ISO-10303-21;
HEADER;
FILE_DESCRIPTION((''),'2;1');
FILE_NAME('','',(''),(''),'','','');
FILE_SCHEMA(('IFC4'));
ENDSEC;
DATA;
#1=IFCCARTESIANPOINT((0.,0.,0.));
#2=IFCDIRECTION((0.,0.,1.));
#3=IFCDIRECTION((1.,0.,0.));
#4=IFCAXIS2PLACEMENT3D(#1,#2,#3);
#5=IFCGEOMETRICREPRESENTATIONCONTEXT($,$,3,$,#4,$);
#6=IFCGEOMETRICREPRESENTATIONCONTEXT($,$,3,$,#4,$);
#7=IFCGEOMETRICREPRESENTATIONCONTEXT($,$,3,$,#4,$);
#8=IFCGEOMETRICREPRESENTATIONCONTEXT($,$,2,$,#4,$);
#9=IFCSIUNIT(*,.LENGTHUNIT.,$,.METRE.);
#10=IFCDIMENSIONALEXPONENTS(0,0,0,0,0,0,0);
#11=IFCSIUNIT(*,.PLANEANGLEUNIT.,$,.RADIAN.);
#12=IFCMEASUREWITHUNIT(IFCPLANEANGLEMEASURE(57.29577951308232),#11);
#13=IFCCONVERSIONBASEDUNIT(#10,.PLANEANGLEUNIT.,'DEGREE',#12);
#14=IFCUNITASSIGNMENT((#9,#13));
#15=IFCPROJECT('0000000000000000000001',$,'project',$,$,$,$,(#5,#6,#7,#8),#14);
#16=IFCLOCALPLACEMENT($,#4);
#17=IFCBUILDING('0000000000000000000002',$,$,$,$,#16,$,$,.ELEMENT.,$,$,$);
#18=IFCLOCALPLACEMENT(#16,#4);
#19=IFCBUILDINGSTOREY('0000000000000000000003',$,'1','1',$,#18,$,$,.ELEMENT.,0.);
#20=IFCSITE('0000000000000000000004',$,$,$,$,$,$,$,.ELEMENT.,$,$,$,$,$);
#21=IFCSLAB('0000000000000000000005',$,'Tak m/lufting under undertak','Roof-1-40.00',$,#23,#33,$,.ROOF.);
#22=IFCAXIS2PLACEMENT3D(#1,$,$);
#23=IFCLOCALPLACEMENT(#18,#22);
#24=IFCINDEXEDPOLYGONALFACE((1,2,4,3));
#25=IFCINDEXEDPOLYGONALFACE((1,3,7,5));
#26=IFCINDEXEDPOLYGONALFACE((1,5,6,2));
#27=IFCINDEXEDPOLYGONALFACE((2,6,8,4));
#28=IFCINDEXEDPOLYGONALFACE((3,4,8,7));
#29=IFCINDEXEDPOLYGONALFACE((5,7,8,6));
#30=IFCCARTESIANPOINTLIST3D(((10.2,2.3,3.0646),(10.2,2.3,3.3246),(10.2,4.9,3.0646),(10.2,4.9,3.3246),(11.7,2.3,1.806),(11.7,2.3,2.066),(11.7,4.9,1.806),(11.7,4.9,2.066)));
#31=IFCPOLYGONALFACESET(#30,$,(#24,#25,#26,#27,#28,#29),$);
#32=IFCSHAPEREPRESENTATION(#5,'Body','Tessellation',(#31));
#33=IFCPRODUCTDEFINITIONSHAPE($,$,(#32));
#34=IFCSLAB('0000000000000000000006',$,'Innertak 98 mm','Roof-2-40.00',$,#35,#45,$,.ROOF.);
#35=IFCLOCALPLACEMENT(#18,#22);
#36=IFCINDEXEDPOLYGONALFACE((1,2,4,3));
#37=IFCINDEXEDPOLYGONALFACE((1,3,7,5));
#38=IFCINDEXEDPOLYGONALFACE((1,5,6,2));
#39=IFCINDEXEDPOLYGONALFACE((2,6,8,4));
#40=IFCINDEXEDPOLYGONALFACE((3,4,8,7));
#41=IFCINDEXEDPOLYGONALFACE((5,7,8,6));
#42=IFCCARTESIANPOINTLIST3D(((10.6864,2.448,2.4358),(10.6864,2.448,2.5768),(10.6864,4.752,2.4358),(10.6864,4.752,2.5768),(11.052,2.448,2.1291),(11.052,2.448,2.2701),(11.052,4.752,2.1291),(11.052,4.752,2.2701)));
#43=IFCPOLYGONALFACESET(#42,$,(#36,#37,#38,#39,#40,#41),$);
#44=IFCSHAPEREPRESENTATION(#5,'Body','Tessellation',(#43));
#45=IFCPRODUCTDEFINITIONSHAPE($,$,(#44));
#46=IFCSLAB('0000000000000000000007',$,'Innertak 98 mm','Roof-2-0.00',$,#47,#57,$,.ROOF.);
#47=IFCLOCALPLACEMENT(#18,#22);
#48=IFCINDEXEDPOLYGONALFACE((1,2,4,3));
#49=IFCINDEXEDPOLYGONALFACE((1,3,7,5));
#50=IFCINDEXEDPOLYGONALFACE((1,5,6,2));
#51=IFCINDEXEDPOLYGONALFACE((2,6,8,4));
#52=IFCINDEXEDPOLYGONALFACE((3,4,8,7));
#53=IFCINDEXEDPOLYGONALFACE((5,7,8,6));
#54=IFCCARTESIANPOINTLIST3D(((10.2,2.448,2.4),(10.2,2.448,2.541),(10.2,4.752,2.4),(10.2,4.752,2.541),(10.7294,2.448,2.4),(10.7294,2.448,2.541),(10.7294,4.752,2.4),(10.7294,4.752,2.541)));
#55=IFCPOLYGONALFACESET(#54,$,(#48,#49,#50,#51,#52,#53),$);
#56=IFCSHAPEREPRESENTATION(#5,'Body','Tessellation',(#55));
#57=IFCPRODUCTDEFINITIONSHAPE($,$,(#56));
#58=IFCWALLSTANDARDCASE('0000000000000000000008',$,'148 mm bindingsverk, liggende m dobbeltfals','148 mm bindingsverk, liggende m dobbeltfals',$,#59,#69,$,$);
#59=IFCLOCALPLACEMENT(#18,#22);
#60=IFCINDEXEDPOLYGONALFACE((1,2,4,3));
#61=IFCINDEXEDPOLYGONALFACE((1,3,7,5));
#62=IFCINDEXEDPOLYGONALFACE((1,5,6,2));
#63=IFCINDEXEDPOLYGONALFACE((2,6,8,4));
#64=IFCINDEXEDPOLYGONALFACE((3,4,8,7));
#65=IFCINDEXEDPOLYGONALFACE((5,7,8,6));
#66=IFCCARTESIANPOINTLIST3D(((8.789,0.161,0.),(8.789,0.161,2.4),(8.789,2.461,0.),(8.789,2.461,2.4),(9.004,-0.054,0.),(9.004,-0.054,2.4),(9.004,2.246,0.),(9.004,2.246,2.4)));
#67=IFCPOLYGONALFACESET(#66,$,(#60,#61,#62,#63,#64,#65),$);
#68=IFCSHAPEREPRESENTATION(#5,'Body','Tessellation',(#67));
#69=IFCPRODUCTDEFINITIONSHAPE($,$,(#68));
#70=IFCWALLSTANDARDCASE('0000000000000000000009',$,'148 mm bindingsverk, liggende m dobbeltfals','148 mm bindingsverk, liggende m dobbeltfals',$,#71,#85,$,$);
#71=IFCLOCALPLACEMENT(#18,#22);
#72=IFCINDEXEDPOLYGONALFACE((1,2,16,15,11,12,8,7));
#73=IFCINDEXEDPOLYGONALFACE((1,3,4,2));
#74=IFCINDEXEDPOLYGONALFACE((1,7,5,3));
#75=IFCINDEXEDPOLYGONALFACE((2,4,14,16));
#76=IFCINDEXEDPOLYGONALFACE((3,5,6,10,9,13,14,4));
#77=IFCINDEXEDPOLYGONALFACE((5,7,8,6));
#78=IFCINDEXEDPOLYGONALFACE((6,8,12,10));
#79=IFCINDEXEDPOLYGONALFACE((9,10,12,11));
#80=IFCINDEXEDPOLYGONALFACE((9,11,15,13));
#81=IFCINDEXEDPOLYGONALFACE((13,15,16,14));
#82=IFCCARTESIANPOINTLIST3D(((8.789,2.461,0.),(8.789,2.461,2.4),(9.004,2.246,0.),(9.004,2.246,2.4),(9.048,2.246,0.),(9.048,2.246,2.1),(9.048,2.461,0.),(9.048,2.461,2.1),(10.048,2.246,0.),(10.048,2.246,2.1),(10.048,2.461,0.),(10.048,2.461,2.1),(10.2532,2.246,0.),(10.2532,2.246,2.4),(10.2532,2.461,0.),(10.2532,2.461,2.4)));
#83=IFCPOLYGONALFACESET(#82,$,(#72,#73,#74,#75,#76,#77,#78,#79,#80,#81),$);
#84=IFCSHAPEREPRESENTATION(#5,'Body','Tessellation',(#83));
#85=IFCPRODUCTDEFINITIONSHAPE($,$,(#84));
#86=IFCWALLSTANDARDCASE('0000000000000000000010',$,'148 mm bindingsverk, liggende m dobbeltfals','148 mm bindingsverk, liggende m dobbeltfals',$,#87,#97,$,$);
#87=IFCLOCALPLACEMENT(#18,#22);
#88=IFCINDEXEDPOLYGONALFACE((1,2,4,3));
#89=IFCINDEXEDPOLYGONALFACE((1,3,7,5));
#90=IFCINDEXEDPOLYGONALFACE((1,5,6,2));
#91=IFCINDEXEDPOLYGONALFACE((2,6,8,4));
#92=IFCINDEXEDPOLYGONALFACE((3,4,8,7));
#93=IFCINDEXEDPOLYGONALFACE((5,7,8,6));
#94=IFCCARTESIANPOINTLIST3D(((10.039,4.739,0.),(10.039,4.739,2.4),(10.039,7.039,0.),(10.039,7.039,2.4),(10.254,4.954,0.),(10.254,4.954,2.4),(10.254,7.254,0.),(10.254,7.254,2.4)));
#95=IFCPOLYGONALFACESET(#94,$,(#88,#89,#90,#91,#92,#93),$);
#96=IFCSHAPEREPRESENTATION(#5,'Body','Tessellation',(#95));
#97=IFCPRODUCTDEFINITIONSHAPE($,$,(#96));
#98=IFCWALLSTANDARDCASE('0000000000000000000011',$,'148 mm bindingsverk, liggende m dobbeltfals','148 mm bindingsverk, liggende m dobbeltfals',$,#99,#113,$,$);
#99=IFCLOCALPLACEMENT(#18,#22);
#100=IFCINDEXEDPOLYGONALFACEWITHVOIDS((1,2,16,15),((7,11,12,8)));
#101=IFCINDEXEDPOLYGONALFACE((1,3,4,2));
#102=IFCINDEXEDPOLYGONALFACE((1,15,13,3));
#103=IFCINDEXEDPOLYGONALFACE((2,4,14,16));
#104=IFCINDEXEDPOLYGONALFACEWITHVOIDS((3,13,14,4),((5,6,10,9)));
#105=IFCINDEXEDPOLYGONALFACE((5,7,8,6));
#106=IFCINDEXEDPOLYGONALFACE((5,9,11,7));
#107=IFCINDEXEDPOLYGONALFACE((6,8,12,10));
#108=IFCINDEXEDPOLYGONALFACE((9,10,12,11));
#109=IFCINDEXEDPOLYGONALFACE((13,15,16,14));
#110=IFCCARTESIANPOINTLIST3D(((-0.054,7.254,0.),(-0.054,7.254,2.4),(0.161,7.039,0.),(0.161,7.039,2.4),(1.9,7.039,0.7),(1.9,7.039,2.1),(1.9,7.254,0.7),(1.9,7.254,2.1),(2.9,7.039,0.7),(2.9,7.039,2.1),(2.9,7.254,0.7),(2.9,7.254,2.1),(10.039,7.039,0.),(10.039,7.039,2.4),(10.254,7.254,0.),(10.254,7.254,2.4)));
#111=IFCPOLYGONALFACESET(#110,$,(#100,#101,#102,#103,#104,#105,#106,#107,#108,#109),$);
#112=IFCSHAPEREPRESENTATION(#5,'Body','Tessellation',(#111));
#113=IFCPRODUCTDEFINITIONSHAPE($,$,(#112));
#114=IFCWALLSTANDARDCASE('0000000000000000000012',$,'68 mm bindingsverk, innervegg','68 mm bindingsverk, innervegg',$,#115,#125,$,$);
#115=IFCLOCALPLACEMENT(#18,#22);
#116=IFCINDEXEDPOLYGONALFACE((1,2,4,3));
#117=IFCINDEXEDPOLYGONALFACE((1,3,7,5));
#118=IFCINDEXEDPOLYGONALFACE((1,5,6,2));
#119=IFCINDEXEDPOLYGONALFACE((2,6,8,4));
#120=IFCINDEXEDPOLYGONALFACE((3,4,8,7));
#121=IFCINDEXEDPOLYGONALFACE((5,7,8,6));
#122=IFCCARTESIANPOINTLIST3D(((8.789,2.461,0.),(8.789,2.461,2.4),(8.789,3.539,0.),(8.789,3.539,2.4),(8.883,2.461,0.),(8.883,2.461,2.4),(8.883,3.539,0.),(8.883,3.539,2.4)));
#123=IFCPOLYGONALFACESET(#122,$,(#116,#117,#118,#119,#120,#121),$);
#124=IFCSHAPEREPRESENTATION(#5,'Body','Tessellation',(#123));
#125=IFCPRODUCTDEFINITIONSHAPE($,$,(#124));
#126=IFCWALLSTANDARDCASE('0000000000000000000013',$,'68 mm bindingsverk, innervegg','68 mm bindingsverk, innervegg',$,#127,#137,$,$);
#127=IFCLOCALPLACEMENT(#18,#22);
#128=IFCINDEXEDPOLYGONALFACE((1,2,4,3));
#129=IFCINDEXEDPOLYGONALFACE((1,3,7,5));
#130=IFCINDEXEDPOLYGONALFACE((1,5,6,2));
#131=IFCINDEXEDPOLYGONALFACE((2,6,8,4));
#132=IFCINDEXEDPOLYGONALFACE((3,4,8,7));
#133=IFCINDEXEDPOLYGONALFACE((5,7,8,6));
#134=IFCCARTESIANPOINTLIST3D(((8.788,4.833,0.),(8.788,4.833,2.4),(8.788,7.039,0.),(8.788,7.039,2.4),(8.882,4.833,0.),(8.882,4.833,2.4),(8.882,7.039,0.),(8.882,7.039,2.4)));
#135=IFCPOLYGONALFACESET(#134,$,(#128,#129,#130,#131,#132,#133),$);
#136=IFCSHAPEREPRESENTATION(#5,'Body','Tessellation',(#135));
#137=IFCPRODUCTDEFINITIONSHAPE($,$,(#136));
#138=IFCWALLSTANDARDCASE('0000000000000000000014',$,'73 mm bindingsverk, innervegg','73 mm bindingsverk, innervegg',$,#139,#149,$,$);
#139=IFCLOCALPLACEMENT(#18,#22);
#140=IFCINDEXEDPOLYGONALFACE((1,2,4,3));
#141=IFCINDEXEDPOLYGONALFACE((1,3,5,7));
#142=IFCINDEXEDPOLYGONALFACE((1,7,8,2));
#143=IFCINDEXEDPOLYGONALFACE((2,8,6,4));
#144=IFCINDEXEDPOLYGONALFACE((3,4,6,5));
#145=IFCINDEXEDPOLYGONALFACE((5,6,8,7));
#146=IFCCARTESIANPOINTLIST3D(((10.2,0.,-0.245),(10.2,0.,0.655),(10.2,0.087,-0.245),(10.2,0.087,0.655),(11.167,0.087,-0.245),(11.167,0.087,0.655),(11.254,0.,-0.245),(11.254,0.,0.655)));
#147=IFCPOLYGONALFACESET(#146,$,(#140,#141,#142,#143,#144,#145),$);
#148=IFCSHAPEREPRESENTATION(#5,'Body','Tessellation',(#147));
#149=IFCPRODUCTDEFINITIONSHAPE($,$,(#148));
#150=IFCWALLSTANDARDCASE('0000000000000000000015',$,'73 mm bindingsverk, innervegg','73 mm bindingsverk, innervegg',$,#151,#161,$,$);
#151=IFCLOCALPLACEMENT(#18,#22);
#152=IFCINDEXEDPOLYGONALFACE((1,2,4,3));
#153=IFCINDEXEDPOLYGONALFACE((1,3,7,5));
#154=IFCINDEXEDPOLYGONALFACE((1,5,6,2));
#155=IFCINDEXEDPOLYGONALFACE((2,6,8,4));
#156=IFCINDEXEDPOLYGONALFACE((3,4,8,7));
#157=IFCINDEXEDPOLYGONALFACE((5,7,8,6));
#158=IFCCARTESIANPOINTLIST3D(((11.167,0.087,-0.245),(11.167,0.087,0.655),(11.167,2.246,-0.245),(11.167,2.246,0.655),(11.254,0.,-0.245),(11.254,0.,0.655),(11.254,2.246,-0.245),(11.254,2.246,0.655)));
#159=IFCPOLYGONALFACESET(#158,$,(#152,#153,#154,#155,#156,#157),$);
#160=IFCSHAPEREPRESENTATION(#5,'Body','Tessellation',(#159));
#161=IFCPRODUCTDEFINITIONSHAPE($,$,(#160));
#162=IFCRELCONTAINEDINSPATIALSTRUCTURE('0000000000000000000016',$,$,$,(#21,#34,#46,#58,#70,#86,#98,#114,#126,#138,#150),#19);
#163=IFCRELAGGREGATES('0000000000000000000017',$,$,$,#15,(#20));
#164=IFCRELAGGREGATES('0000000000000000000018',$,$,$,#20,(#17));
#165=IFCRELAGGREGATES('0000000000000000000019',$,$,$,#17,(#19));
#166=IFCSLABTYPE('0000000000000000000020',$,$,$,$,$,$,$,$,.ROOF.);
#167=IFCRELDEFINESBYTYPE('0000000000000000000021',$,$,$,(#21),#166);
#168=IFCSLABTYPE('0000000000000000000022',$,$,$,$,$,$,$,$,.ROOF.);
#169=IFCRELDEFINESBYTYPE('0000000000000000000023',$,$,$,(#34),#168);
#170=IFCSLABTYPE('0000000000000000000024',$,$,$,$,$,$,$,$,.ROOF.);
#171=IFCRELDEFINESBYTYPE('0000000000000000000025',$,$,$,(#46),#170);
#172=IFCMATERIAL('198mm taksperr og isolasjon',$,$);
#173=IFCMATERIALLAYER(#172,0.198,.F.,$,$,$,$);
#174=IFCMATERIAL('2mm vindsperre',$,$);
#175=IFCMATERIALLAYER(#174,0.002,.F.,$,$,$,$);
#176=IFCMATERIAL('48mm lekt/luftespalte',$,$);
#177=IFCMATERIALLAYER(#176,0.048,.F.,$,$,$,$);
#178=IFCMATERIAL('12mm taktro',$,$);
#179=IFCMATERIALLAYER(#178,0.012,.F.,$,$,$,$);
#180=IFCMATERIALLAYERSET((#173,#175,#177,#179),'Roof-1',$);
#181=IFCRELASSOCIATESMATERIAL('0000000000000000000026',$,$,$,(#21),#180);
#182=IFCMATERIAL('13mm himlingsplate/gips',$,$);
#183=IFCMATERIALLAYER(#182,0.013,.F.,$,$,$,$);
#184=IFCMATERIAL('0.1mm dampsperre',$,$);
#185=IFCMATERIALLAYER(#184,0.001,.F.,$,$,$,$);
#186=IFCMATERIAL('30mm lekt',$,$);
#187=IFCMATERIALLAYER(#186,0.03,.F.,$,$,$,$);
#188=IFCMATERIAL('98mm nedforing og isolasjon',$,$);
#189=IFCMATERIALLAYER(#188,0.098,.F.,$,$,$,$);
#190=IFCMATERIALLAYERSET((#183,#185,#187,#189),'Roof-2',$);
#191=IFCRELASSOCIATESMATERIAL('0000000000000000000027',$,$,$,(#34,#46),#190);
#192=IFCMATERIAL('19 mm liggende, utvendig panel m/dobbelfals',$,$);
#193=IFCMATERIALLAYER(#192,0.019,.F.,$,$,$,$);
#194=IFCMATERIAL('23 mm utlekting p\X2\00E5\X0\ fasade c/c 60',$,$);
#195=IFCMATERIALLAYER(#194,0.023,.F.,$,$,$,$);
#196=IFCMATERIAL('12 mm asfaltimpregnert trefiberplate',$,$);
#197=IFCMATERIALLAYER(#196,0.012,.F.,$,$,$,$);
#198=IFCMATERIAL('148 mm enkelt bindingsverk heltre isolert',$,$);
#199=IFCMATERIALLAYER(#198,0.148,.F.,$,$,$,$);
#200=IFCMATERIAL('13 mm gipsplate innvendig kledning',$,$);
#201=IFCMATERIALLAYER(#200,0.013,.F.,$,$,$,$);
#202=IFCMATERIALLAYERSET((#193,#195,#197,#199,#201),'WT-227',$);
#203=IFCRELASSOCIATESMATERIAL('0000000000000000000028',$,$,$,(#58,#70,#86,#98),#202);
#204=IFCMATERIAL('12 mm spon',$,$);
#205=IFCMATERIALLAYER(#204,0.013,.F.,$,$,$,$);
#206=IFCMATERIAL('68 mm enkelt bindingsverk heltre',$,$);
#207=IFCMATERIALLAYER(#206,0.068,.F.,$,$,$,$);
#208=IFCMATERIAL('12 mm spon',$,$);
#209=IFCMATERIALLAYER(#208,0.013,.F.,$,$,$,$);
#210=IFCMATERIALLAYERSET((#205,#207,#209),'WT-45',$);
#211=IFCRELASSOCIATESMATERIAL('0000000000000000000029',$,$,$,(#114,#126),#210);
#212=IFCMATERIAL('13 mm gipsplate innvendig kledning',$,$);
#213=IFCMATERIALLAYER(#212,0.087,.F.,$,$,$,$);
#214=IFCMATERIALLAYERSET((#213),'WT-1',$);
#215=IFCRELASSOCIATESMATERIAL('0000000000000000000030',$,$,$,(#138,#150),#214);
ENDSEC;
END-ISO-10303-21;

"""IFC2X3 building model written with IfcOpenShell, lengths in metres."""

from ifc_helpers import new_model, entity, si_unit, converted_unit, frame, origin_with_axes, place, context, project, spatial, polyline, outline, extrude, material, layer, layer_set, layer_usage, type_object, element, save


model = new_model("IFC2X3")

# Units and contexts
context_of_model_1 = context(None, 3, world=origin_with_axes())
context_of_model_2 = context(None, 3, world=origin_with_axes())
context_of_model_3 = context(None, 3, world=origin_with_axes())
context_of_model_4 = context(None, 2, world=origin_with_axes())
ifc_project = project(units=[si_unit("LENGTHUNIT", "METRE"), converted_unit("PLANEANGLEUNIT", "DEGREE", entity("IfcPlaneAngleMeasure", 57.29577951308232), si_unit("PLANEANGLEUNIT", "RADIAN"), dimensions=[0, 0, 0, 0, 0, 0, 0])], contexts=[context_of_model_1, context_of_model_2, context_of_model_3, context_of_model_4])

# Site, building, storey
site = spatial("IfcSite", under=ifc_project, CompositionType="ELEMENT")
building_placement = place(None, origin_with_axes())
building = spatial("IfcBuilding", under=site, at=building_placement, CompositionType="ELEMENT")
storey_placement = place(building_placement, origin_with_axes())
storey = spatial("IfcBuildingStorey", under=building, at=storey_placement, Name="1", Description="1", CompositionType="ELEMENT", Elevation=0.0)

# Slabs
ifc_material_1 = material(Name="198mm taksperr og isolasjon")
ifc_layer_1 = layer(ifc_material_1, 0.198, ventilated=False)
ifc_material_2 = material(Name="2mm vindsperre")
ifc_layer_2 = layer(ifc_material_2, 0.002, ventilated=False)
ifc_material_3 = material(Name="48mm lekt/luftespalte")
ifc_layer_3 = layer(ifc_material_3, 0.048, ventilated=False)
ifc_material_4 = material(Name="12mm taktro")
ifc_layer_4 = layer(ifc_material_4, 0.012, ventilated=False)
ifc_layer_set_1 = layer_set([ifc_layer_1, ifc_layer_2, ifc_layer_3, ifc_layer_4], Name="Roof-1")
ifc_layer_usage_1 = layer_usage(ifc_layer_set_1, "AXIS3", "NEGATIVE", 0.0)
slab_type_1 = type_object("IfcSlabType", PredefinedType="ROOF")
slab_1_placement = place(storey_placement, frame((10.2, 4.9, 3.0646), z_axis=(0.642788, 0.000003, 0.766044), x_axis=(0.000004, -1.0, 0.0)))
element("IfcSlab", 1, at=slab_1_placement, inside=storey, type_object=slab_type_1, material=ifc_layer_usage_1, Name="Tak m/lufting under undertak", Description="Roof-1-40.00", PredefinedType="ROOF", context=context_of_model_1, shape_type="SweptSolid", body=[
    extrude(outline(polyline([(0.0, 0.0), (1.9581, 0.0), (1.9581, 2.6), (0.0, 2.6), (0.0, 0.0)])), frame((0.0, 0.0, 0.0), z_axis=(0.0, 0.0, -1.0), x_axis=(0.0, 1.0, 0.0)), (-0.642788, 0.0, -0.766044), 0.26),
])
ifc_material_5 = material(Name="13mm himlingsplate/gips")
ifc_layer_5 = layer(ifc_material_5, 0.013, ventilated=False)
ifc_material_6 = material(Name="0.1mm dampsperre")
ifc_layer_6 = layer(ifc_material_6, 0.001, ventilated=False)
ifc_material_7 = material(Name="30mm lekt")
ifc_layer_7 = layer(ifc_material_7, 0.03, ventilated=False)
ifc_material_8 = material(Name="98mm nedforing og isolasjon")
ifc_layer_8 = layer(ifc_material_8, 0.098, ventilated=False)
ifc_layer_set_2 = layer_set([ifc_layer_5, ifc_layer_6, ifc_layer_7, ifc_layer_8], Name="Roof-2")
ifc_layer_usage_2 = layer_usage(ifc_layer_set_2, "AXIS3", "NEGATIVE", 0.0)
slab_type_2 = type_object("IfcSlabType", PredefinedType="ROOF")
slab_2_placement = place(storey_placement, frame((10.6864, 4.752, 2.4358), z_axis=(0.642787, 0.0, 0.766045), x_axis=(0.0, -1.0, 0.0)))
element("IfcSlab", 2, at=slab_2_placement, inside=storey, type_object=slab_type_2, material=ifc_layer_usage_2, Name="Innertak 98 mm", Description="Roof-2-40.00", PredefinedType="ROOF", context=context_of_model_1, shape_type="SweptSolid", body=[
    extrude(outline(polyline([(0.0, 0.0), (2.304, 0.0), (2.304, 0.4772), (0.0, 0.4772), (0.0, 0.0)])), origin_with_axes(), (0.0, -0.642787, 0.766045), 0.141),
])
slab_type_3 = type_object("IfcSlabType", PredefinedType="ROOF")
slab_3_placement = place(storey_placement, frame((10.2, 4.752, 2.4), z_axis=(0.0, 0.0, 1.0), x_axis=(0.0, -1.0, 0.0)))
element("IfcSlab", 3, at=slab_3_placement, inside=storey, type_object=slab_type_3, material=ifc_layer_usage_2, Name="Innertak 98 mm", Description="Roof-2-0.00", PredefinedType="ROOF", context=context_of_model_1, shape_type="SweptSolid", body=[
    extrude(outline(polyline([(0.0, 0.0), (2.304, 0.0), (2.304, 0.5294), (0.0, 0.5294), (0.0, 0.0)])), origin_with_axes(), (0.0, 0.0, 1.0), 0.141),
])

# Wall
ifc_material_9 = material(Name="19 mm liggende, utvendig panel m/dobbelfals")
ifc_layer_9 = layer(ifc_material_9, 0.019, ventilated=False)
ifc_material_10 = material(Name="23 mm utlekting på fasade c/c 60")
ifc_layer_10 = layer(ifc_material_10, 0.023, ventilated=False)
ifc_material_11 = material(Name="12 mm asfaltimpregnert trefiberplate")
ifc_layer_11 = layer(ifc_material_11, 0.012, ventilated=False)
ifc_material_12 = material(Name="148 mm enkelt bindingsverk heltre isolert")
ifc_layer_12 = layer(ifc_material_12, 0.148, ventilated=False)
ifc_material_13 = material(Name="13 mm gipsplate innvendig kledning")
ifc_layer_13 = layer(ifc_material_13, 0.013, ventilated=False)
ifc_layer_set_3 = layer_set([ifc_layer_9, ifc_layer_10, ifc_layer_11, ifc_layer_12, ifc_layer_13], Name="WT-227")
ifc_layer_usage_3 = layer_usage(ifc_layer_set_3, "AXIS2", "POSITIVE", 0.0)
wall_1_placement = place(storey_placement, frame((9.004, -0.054, 0.0), z_axis=(0.0, 0.0, 1.0), x_axis=(0.0, 1.0, 0.0)))
element("IfcWallStandardCase", 4, at=wall_1_placement, inside=storey, material=ifc_layer_usage_3, Name="148 mm bindingsverk, liggende m dobbeltfals", Description="148 mm bindingsverk, liggende m dobbeltfals", context=context_of_model_1, shape_type="SweptSolid", body=[
    extrude(outline(polyline([(0.0, 0.0), (2.3, 0.0), (2.515, 0.215), (0.215, 0.215), (0.0, 0.0)])), frame((0.0, 0.0, 0.0), z_axis=(0.0, 0.0, 1.0), x_axis=(1.0, 0.0, 0.0)), (0.0, 0.0, 1.0), 2.4),
])

# Wall, opening
wall_2_placement = place(storey_placement, frame((9.004, 2.246, 0.0), z_axis=(0.0, 0.0, 1.0), x_axis=(1.0, 0.0, 0.0)))
wall_2 = element("IfcWallStandardCase", 5, at=wall_2_placement, inside=storey, material=ifc_layer_usage_3, Name="148 mm bindingsverk, liggende m dobbeltfals", Description="148 mm bindingsverk, liggende m dobbeltfals", context=context_of_model_1, shape_type="SweptSolid", body=[
    extrude(outline(polyline([(0.0, 0.0), (1.2492, 0.0), (1.2492, 0.215), (-0.215, 0.215), (0.0, 0.0)])), frame((0.0, 0.0, 0.0), z_axis=(0.0, 0.0, 1.0), x_axis=(1.0, 0.0, 0.0)), (0.0, 0.0, 1.0), 2.4),
])
opening_1_placement = place(wall_2_placement, frame((0.044, 0.0, 0.0), z_axis=(0.0, 0.0, 1.0), x_axis=(1.0, 0.0, 0.0)))
element("IfcOpeningElement", 6, at=opening_1_placement, inside=storey, cuts=wall_2, context=context_of_model_1, shape_type="SweptSolid", body=[
    extrude(outline(polyline([(0.0, 0.0), (2.1, 0.0), (2.1, 1.0), (0.0, 1.0), (0.0, 0.0)])), frame((0.0, 0.0, 0.0), z_axis=(0.0, 1.0, 0.0), x_axis=(0.0, 0.0, 1.0)), (0.0, 0.0, 1.0), 0.215),
])

# Wall
wall_3_placement = place(storey_placement, frame((10.254, 4.954, 0.0), z_axis=(0.0, 0.0, 1.0), x_axis=(0.0, 1.0, 0.0)))
element("IfcWallStandardCase", 7, at=wall_3_placement, inside=storey, material=ifc_layer_usage_3, Name="148 mm bindingsverk, liggende m dobbeltfals", Description="148 mm bindingsverk, liggende m dobbeltfals", context=context_of_model_1, shape_type="SweptSolid", body=[
    extrude(outline(polyline([(0.0, 0.0), (2.3, 0.0), (2.085, 0.215), (-0.215, 0.215), (0.0, 0.0)])), frame((0.0, 0.0, 0.0), z_axis=(0.0, 0.0, 1.0), x_axis=(1.0, 0.0, 0.0)), (0.0, 0.0, 1.0), 2.4),
])

# Wall, opening
wall_4_placement = place(storey_placement, frame((10.254, 7.254, 0.0), z_axis=(0.0, 0.0, 1.0), x_axis=(-1.0, 0.0, 0.0)))
wall_4 = element("IfcWallStandardCase", 8, at=wall_4_placement, inside=storey, material=ifc_layer_usage_3, Name="148 mm bindingsverk, liggende m dobbeltfals", Description="148 mm bindingsverk, liggende m dobbeltfals", context=context_of_model_1, shape_type="SweptSolid", body=[
    extrude(outline(polyline([(0.0, 0.0), (10.308, 0.0), (10.093, 0.215), (0.215, 0.215), (0.0, 0.0)])), frame((0.0, 0.0, 0.0), z_axis=(0.0, 0.0, 1.0), x_axis=(1.0, 0.0, 0.0)), (0.0, 0.0, 1.0), 2.4),
])
opening_2_placement = place(wall_4_placement, frame((7.354, 0.0, 0.7), z_axis=(0.0, 0.0, 1.0), x_axis=(1.0, 0.0, 0.0)))
element("IfcOpeningElement", 9, at=opening_2_placement, inside=storey, cuts=wall_4, context=context_of_model_1, shape_type="SweptSolid", body=[
    extrude(outline(polyline([(0.0, 0.0), (1.4, 0.0), (1.4, 1.0), (0.0, 1.0), (0.0, 0.0)])), frame((0.0, 0.0, 0.0), z_axis=(0.0, 1.0, 0.0), x_axis=(0.0, 0.0, 1.0)), (0.0, 0.0, 1.0), 0.215),
])

# Walls
ifc_material_14 = material(Name="12 mm spon")
ifc_layer_14 = layer(ifc_material_14, 0.013, ventilated=False)
ifc_material_15 = material(Name="68 mm enkelt bindingsverk heltre")
ifc_layer_15 = layer(ifc_material_15, 0.068, ventilated=False)
ifc_material_16 = material(Name="12 mm spon")
ifc_layer_16 = layer(ifc_material_16, 0.013, ventilated=False)
ifc_layer_set_4 = layer_set([ifc_layer_14, ifc_layer_15, ifc_layer_16], Name="WT-45")
ifc_layer_usage_4 = layer_usage(ifc_layer_set_4, "AXIS2", "POSITIVE", 0.0)
wall_5_placement = place(storey_placement, frame((8.883, 2.461, 0.0), z_axis=(0.0, 0.0, 1.0), x_axis=(0.0, 1.0, 0.0)))
element("IfcWallStandardCase", 10, at=wall_5_placement, inside=storey, material=ifc_layer_usage_4, Name="68 mm bindingsverk, innervegg", Description="68 mm bindingsverk, innervegg", context=context_of_model_1, shape_type="SweptSolid", body=[
    extrude(outline(polyline([(0.0, 0.0), (1.078, 0.0), (1.078, 0.094), (0.0, 0.094), (0.0, 0.0)])), frame((0.0, 0.0, 0.0), z_axis=(0.0, 0.0, 1.0), x_axis=(1.0, 0.0, 0.0)), (0.0, 0.0, 1.0), 2.4),
])
wall_6_placement = place(storey_placement, frame((8.882, 4.833, 0.0), z_axis=(0.0, 0.0, 1.0), x_axis=(0.0, 1.0, 0.0)))
element("IfcWallStandardCase", 11, at=wall_6_placement, inside=storey, material=ifc_layer_usage_4, Name="68 mm bindingsverk, innervegg", Description="68 mm bindingsverk, innervegg", context=context_of_model_1, shape_type="SweptSolid", body=[
    extrude(outline(polyline([(0.0, 0.0), (2.206, 0.0), (2.206, 0.094), (0.0, 0.094), (0.0, 0.0)])), frame((0.0, 0.0, 0.0), z_axis=(0.0, 0.0, 1.0), x_axis=(1.0, 0.0, 0.0)), (0.0, 0.0, 1.0), 2.4),
])
ifc_material_17 = material(Name="13 mm gipsplate innvendig kledning")
ifc_layer_17 = layer(ifc_material_17, 0.087, ventilated=False)
ifc_layer_set_5 = layer_set([ifc_layer_17], Name="WT-1")
ifc_layer_usage_5 = layer_usage(ifc_layer_set_5, "AXIS2", "POSITIVE", 0.0)
wall_7_placement = place(storey_placement, frame((10.2, 0.0, -0.245), z_axis=(0.0, 0.0, 1.0), x_axis=(1.0, 0.0, 0.0)))
element("IfcWallStandardCase", 12, at=wall_7_placement, inside=storey, material=ifc_layer_usage_5, Name="73 mm bindingsverk, innervegg", Description="73 mm bindingsverk, innervegg", context=context_of_model_1, shape_type="SweptSolid", body=[
    extrude(outline(polyline([(0.0, 0.0), (1.054, 0.0), (0.967, 0.087), (0.0, 0.087), (0.0, 0.0)])), origin_with_axes(), (0.0, 0.0, 1.0), 0.9),
])
wall_8_placement = place(storey_placement, frame((11.254, 0.0, -0.245), z_axis=(0.0, 0.0, 1.0), x_axis=(0.0, 1.0, 0.0)))
element("IfcWallStandardCase", 13, at=wall_8_placement, inside=storey, material=ifc_layer_usage_5, Name="73 mm bindingsverk, innervegg", Description="73 mm bindingsverk, innervegg", context=context_of_model_1, shape_type="SweptSolid", body=[
    extrude(outline(polyline([(0.0, 0.0), (2.246, 0.0), (2.246, 0.087), (0.087, 0.087), (0.0, 0.0)])), frame((0.0, 0.0, 0.0), z_axis=(0.0, 0.0, 1.0), x_axis=(1.0, 0.0, 0.0)), (0.0, 0.0, 1.0), 0.9),
])

save(model, "model.ifc")
